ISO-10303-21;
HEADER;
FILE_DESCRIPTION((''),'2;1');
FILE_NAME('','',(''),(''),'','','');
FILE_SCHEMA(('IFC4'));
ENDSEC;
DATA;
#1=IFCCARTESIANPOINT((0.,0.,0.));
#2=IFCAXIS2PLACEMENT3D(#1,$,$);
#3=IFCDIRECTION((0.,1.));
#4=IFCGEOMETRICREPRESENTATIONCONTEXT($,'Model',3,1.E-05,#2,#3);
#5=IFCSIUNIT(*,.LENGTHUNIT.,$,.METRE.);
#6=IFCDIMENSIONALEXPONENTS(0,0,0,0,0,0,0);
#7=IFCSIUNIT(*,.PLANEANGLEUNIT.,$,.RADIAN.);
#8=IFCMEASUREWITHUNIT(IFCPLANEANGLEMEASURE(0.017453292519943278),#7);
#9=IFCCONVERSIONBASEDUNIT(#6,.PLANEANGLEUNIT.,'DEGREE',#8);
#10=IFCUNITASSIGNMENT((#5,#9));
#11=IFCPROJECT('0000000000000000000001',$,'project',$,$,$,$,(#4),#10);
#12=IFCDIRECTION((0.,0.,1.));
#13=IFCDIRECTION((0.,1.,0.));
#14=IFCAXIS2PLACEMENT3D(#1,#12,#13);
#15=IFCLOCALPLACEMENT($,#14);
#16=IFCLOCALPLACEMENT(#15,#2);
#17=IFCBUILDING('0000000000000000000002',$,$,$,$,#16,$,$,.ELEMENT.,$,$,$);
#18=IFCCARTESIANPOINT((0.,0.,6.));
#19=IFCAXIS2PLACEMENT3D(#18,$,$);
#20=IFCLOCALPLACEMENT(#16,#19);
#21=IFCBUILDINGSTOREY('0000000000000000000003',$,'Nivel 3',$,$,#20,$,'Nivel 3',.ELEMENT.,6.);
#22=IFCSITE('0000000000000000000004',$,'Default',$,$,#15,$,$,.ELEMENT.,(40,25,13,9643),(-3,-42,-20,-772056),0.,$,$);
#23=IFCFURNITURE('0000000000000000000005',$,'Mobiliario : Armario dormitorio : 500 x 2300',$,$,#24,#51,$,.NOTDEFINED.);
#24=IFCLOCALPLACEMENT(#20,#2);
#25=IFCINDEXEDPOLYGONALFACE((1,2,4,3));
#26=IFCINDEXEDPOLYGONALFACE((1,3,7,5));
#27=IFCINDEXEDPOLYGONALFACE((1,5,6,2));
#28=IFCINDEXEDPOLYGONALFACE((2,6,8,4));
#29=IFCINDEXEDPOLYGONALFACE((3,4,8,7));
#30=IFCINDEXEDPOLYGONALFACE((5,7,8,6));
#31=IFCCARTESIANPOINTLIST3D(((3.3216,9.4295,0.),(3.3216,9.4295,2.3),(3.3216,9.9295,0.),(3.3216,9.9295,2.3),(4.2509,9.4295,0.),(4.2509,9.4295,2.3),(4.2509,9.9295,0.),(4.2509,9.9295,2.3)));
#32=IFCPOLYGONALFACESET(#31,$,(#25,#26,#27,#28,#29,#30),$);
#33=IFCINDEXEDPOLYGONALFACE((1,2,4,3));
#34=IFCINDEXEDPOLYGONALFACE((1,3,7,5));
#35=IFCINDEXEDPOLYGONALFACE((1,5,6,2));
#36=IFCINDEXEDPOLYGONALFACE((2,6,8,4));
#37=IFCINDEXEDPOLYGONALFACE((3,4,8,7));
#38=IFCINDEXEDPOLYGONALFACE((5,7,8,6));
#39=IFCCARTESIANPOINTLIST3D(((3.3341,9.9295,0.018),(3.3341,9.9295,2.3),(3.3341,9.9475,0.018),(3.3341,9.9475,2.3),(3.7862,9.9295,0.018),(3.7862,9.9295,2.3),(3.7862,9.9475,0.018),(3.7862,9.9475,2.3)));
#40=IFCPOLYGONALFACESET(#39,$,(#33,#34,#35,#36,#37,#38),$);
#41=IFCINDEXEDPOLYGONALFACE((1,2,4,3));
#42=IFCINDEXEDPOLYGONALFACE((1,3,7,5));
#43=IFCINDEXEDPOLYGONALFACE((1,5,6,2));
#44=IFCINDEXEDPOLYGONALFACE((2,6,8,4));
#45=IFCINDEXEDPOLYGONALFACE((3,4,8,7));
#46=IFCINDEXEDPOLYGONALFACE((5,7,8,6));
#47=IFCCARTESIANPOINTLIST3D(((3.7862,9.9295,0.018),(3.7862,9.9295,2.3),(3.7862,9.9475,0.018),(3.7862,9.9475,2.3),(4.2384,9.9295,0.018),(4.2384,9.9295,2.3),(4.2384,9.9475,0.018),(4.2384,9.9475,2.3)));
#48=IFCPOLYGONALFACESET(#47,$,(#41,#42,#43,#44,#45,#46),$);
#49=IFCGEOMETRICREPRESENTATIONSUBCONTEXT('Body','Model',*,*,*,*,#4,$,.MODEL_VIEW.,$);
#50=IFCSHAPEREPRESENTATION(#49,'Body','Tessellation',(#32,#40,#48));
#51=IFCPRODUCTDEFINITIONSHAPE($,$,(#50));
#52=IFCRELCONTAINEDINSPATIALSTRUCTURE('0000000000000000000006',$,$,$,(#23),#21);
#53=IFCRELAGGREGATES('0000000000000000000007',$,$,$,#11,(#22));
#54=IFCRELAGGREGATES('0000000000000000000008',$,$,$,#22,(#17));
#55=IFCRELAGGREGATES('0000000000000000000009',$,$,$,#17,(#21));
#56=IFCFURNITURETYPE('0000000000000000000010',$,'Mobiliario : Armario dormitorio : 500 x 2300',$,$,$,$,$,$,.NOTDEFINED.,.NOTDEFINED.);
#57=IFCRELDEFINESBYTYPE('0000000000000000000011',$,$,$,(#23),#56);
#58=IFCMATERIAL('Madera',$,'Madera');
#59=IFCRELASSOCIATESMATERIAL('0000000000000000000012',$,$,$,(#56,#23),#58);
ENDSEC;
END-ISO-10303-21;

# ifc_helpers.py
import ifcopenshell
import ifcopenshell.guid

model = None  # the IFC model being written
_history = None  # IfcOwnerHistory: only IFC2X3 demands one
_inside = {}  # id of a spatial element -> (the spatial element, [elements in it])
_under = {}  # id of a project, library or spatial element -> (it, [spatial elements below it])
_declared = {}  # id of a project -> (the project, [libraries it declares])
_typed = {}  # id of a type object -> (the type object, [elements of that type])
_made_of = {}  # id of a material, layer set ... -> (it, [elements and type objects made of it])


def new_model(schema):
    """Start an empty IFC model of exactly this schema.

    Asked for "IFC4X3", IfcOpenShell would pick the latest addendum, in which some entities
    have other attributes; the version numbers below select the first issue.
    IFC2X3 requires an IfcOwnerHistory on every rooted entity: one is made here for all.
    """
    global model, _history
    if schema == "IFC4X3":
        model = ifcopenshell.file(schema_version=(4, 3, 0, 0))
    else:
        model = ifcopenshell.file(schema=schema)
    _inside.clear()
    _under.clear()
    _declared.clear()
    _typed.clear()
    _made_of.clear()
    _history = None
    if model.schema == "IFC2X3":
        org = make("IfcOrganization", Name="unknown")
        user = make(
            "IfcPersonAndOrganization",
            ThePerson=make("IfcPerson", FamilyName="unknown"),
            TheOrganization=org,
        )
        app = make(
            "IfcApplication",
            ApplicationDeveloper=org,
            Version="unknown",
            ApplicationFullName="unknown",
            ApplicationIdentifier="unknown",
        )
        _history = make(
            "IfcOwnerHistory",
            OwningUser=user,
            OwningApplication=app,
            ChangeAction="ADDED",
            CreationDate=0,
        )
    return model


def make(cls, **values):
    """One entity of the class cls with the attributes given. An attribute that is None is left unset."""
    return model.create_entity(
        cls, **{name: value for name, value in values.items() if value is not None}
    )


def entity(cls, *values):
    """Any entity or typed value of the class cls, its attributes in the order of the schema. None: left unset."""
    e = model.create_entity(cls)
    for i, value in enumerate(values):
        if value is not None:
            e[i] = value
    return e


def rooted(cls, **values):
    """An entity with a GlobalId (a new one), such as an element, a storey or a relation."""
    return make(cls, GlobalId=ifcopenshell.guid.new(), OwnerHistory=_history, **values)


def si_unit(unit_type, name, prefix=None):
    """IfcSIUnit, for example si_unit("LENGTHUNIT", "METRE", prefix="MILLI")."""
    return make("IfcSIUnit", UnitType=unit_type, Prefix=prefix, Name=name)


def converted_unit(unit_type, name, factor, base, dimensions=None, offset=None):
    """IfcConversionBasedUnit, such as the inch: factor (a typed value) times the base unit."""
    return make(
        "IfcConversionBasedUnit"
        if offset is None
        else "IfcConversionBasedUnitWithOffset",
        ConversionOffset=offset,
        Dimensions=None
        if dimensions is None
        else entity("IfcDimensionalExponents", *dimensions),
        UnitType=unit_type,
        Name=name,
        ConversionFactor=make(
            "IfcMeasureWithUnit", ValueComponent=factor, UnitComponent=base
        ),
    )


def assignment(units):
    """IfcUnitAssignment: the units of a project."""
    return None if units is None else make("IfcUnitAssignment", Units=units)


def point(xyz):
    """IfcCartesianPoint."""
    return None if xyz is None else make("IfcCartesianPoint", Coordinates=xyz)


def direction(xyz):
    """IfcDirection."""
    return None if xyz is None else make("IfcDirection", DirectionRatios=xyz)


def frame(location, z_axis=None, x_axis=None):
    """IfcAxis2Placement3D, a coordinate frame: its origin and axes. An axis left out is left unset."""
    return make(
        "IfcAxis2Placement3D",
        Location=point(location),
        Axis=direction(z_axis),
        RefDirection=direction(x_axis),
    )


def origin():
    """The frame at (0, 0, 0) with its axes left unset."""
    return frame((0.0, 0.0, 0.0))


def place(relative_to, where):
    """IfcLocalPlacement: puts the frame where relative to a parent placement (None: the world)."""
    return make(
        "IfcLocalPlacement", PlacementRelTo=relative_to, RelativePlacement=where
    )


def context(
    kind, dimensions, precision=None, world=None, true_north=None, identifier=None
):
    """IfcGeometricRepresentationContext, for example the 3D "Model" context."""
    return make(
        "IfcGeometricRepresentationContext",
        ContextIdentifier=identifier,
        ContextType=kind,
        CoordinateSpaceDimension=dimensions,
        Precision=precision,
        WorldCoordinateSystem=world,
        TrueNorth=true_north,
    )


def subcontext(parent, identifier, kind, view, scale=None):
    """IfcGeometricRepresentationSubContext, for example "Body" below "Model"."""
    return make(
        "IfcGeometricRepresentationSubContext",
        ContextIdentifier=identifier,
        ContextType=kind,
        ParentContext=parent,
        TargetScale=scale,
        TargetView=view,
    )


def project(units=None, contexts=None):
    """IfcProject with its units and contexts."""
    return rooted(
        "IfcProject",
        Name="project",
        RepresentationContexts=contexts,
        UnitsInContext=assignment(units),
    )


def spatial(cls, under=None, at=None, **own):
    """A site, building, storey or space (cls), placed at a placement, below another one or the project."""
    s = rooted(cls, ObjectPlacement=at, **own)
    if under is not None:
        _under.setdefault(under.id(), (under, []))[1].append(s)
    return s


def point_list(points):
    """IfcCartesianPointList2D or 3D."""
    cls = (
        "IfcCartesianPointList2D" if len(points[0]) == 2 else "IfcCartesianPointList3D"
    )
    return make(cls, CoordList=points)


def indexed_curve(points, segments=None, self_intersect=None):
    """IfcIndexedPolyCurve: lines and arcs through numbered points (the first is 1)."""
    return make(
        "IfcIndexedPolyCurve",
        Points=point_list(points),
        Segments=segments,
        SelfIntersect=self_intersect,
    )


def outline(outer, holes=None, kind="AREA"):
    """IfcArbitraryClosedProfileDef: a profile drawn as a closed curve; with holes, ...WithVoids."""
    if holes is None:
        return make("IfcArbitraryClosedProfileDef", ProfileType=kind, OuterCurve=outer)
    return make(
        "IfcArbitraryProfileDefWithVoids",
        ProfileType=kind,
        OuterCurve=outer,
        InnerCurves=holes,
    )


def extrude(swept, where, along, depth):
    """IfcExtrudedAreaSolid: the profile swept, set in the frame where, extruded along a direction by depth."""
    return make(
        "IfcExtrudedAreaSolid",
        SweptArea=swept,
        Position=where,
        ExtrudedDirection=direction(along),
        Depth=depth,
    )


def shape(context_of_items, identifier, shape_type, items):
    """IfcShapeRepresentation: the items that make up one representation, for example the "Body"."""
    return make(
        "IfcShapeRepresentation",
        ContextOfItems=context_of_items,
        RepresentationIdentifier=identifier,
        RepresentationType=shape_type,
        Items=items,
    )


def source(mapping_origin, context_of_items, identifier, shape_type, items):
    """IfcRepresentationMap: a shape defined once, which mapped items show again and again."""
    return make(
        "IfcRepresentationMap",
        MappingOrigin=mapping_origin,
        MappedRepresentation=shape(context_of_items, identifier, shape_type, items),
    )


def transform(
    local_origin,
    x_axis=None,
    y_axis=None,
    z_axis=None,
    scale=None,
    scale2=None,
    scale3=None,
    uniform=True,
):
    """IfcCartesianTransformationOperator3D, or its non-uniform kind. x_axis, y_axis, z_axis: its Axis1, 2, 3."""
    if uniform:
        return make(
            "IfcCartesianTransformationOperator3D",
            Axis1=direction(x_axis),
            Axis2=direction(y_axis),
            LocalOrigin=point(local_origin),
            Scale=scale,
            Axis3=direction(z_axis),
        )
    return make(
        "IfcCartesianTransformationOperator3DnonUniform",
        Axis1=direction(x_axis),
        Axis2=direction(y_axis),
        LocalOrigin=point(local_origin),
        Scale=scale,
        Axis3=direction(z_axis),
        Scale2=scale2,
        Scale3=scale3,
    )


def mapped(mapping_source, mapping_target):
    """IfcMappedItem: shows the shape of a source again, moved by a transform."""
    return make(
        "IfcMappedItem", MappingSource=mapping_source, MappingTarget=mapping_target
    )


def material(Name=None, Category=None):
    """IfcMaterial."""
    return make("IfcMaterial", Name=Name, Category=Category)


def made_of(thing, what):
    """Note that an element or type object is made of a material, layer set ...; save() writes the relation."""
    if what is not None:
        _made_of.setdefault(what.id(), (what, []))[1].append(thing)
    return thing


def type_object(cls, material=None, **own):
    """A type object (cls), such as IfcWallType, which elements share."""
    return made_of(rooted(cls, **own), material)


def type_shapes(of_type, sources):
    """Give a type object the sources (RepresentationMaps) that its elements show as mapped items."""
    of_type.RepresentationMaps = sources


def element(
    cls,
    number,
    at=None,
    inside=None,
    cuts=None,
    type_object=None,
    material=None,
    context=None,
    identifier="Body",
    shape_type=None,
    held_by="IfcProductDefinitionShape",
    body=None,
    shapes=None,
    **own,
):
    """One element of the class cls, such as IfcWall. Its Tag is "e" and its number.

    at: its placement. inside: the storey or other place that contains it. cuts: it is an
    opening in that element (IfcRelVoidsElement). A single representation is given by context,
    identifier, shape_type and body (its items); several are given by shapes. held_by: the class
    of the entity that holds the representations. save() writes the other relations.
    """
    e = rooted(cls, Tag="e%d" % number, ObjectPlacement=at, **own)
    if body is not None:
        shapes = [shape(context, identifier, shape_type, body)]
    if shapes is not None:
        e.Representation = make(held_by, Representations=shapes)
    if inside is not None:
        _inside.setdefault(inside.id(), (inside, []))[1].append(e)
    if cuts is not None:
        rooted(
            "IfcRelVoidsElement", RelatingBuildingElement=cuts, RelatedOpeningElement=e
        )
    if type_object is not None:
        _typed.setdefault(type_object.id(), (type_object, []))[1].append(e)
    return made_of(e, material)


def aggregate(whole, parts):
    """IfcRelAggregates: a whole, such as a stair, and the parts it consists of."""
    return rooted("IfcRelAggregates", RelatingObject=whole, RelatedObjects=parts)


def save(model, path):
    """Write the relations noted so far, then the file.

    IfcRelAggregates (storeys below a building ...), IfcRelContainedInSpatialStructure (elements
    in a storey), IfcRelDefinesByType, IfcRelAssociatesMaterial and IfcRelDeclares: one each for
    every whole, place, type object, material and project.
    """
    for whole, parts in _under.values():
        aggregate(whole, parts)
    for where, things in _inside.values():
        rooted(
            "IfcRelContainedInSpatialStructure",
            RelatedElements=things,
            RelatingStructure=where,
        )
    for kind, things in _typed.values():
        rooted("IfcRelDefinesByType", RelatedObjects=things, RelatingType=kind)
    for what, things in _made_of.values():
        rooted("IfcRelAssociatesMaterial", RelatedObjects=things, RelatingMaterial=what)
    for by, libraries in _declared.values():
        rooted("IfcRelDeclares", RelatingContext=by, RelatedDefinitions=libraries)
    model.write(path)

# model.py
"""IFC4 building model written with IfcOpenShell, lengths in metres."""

from ifc_helpers import new_model, entity, si_unit, converted_unit, direction, frame, origin, place, context, subcontext, project, spatial, indexed_curve, outline, extrude, source, transform, mapped, material, type_object, type_shapes, element, save


model = new_model("IFC4")

# Units and contexts
model_context = context("Model", 3, precision=1e-05, world=origin(), true_north=direction((0.0, 1.0)))
body_context = subcontext(model_context, "Body", "Model", "MODEL_VIEW")
ifc_project = project(units=[si_unit("LENGTHUNIT", "METRE"), converted_unit("PLANEANGLEUNIT", "DEGREE", entity("IfcPlaneAngleMeasure", 0.017453292519943278), si_unit("PLANEANGLEUNIT", "RADIAN"), dimensions=[0, 0, 0, 0, 0, 0, 0])], contexts=[model_context])

# Site, building, storey
site_placement = place(None, frame((0.0, 0.0, 0.0), z_axis=(0.0, 0.0, 1.0), x_axis=(0.0, 1.0, 0.0)))
site = spatial("IfcSite", under=ifc_project, at=site_placement, Name="Default", CompositionType="ELEMENT", RefLatitude=(40, 25, 13, 9643), RefLongitude=(-3, -42, -20, -772056), RefElevation=0.0)
building_placement = place(site_placement, origin())
building = spatial("IfcBuilding", under=site, at=building_placement, CompositionType="ELEMENT")
storey_placement = place(building_placement, frame((0.0, 0.0, 6.0)))
storey = spatial("IfcBuildingStorey", under=building, at=storey_placement, Name="Nivel 3", LongName="Nivel 3", CompositionType="ELEMENT", Elevation=6.0)

# Furniture
ifc_material_1 = material(Name="Madera", Category="Madera")
furniture_type_1 = type_object("IfcFurnitureType", Name="Mobiliario : Armario dormitorio : 500 x 2300", AssemblyPlace="NOTDEFINED", PredefinedType="NOTDEFINED", material=ifc_material_1)
shared_shape_1 = source(origin(), body_context, "Body", "SweptSolid", [
    extrude(outline(indexed_curve([(-0.25, -0.4646), (0.25, -0.4646), (0.25, 0.4646), (-0.25, 0.4646), (-0.25, -0.4646)], self_intersect=False)), frame((0.0, 0.25, 0.0), z_axis=(0.0, 0.0, 1.0), x_axis=(0.0, 1.0, 0.0)), (0.0, 0.0, 1.0), 2.3),
    extrude(outline(indexed_curve([(-0.009, -0.2261), (0.009, -0.2261), (0.009, 0.2261), (-0.009, 0.2261), (-0.009, -0.2261)], self_intersect=False)), frame((-0.2261, 0.509, 0.018), z_axis=(0.0, 0.0, 1.0), x_axis=(0.0, 1.0, 0.0)), (0.0, 0.0, 1.0), 2.282),
    extrude(outline(indexed_curve([(-0.2261, -0.009), (0.2261, -0.009), (0.2261, 0.009), (-0.2261, 0.009), (-0.2261, -0.009)], self_intersect=False)), frame((0.2261, 0.509, 0.018)), (0.0, 0.0, 1.0), 2.282),
])
type_shapes(furniture_type_1, [shared_shape_1])
furniture_1_placement = place(storey_placement, frame((3.7862, 9.4295, 0.0)))
element("IfcFurniture", 1, at=furniture_1_placement, inside=storey, type_object=furniture_type_1, material=ifc_material_1, Name="Mobiliario : Armario dormitorio : 500 x 2300", PredefinedType="NOTDEFINED", context=body_context, shape_type="MappedRepresentation", body=[
    mapped(shared_shape_1, transform((0.0, 0.0, 0.0), scale=1.0)),
])

save(model, "model.ifc")
